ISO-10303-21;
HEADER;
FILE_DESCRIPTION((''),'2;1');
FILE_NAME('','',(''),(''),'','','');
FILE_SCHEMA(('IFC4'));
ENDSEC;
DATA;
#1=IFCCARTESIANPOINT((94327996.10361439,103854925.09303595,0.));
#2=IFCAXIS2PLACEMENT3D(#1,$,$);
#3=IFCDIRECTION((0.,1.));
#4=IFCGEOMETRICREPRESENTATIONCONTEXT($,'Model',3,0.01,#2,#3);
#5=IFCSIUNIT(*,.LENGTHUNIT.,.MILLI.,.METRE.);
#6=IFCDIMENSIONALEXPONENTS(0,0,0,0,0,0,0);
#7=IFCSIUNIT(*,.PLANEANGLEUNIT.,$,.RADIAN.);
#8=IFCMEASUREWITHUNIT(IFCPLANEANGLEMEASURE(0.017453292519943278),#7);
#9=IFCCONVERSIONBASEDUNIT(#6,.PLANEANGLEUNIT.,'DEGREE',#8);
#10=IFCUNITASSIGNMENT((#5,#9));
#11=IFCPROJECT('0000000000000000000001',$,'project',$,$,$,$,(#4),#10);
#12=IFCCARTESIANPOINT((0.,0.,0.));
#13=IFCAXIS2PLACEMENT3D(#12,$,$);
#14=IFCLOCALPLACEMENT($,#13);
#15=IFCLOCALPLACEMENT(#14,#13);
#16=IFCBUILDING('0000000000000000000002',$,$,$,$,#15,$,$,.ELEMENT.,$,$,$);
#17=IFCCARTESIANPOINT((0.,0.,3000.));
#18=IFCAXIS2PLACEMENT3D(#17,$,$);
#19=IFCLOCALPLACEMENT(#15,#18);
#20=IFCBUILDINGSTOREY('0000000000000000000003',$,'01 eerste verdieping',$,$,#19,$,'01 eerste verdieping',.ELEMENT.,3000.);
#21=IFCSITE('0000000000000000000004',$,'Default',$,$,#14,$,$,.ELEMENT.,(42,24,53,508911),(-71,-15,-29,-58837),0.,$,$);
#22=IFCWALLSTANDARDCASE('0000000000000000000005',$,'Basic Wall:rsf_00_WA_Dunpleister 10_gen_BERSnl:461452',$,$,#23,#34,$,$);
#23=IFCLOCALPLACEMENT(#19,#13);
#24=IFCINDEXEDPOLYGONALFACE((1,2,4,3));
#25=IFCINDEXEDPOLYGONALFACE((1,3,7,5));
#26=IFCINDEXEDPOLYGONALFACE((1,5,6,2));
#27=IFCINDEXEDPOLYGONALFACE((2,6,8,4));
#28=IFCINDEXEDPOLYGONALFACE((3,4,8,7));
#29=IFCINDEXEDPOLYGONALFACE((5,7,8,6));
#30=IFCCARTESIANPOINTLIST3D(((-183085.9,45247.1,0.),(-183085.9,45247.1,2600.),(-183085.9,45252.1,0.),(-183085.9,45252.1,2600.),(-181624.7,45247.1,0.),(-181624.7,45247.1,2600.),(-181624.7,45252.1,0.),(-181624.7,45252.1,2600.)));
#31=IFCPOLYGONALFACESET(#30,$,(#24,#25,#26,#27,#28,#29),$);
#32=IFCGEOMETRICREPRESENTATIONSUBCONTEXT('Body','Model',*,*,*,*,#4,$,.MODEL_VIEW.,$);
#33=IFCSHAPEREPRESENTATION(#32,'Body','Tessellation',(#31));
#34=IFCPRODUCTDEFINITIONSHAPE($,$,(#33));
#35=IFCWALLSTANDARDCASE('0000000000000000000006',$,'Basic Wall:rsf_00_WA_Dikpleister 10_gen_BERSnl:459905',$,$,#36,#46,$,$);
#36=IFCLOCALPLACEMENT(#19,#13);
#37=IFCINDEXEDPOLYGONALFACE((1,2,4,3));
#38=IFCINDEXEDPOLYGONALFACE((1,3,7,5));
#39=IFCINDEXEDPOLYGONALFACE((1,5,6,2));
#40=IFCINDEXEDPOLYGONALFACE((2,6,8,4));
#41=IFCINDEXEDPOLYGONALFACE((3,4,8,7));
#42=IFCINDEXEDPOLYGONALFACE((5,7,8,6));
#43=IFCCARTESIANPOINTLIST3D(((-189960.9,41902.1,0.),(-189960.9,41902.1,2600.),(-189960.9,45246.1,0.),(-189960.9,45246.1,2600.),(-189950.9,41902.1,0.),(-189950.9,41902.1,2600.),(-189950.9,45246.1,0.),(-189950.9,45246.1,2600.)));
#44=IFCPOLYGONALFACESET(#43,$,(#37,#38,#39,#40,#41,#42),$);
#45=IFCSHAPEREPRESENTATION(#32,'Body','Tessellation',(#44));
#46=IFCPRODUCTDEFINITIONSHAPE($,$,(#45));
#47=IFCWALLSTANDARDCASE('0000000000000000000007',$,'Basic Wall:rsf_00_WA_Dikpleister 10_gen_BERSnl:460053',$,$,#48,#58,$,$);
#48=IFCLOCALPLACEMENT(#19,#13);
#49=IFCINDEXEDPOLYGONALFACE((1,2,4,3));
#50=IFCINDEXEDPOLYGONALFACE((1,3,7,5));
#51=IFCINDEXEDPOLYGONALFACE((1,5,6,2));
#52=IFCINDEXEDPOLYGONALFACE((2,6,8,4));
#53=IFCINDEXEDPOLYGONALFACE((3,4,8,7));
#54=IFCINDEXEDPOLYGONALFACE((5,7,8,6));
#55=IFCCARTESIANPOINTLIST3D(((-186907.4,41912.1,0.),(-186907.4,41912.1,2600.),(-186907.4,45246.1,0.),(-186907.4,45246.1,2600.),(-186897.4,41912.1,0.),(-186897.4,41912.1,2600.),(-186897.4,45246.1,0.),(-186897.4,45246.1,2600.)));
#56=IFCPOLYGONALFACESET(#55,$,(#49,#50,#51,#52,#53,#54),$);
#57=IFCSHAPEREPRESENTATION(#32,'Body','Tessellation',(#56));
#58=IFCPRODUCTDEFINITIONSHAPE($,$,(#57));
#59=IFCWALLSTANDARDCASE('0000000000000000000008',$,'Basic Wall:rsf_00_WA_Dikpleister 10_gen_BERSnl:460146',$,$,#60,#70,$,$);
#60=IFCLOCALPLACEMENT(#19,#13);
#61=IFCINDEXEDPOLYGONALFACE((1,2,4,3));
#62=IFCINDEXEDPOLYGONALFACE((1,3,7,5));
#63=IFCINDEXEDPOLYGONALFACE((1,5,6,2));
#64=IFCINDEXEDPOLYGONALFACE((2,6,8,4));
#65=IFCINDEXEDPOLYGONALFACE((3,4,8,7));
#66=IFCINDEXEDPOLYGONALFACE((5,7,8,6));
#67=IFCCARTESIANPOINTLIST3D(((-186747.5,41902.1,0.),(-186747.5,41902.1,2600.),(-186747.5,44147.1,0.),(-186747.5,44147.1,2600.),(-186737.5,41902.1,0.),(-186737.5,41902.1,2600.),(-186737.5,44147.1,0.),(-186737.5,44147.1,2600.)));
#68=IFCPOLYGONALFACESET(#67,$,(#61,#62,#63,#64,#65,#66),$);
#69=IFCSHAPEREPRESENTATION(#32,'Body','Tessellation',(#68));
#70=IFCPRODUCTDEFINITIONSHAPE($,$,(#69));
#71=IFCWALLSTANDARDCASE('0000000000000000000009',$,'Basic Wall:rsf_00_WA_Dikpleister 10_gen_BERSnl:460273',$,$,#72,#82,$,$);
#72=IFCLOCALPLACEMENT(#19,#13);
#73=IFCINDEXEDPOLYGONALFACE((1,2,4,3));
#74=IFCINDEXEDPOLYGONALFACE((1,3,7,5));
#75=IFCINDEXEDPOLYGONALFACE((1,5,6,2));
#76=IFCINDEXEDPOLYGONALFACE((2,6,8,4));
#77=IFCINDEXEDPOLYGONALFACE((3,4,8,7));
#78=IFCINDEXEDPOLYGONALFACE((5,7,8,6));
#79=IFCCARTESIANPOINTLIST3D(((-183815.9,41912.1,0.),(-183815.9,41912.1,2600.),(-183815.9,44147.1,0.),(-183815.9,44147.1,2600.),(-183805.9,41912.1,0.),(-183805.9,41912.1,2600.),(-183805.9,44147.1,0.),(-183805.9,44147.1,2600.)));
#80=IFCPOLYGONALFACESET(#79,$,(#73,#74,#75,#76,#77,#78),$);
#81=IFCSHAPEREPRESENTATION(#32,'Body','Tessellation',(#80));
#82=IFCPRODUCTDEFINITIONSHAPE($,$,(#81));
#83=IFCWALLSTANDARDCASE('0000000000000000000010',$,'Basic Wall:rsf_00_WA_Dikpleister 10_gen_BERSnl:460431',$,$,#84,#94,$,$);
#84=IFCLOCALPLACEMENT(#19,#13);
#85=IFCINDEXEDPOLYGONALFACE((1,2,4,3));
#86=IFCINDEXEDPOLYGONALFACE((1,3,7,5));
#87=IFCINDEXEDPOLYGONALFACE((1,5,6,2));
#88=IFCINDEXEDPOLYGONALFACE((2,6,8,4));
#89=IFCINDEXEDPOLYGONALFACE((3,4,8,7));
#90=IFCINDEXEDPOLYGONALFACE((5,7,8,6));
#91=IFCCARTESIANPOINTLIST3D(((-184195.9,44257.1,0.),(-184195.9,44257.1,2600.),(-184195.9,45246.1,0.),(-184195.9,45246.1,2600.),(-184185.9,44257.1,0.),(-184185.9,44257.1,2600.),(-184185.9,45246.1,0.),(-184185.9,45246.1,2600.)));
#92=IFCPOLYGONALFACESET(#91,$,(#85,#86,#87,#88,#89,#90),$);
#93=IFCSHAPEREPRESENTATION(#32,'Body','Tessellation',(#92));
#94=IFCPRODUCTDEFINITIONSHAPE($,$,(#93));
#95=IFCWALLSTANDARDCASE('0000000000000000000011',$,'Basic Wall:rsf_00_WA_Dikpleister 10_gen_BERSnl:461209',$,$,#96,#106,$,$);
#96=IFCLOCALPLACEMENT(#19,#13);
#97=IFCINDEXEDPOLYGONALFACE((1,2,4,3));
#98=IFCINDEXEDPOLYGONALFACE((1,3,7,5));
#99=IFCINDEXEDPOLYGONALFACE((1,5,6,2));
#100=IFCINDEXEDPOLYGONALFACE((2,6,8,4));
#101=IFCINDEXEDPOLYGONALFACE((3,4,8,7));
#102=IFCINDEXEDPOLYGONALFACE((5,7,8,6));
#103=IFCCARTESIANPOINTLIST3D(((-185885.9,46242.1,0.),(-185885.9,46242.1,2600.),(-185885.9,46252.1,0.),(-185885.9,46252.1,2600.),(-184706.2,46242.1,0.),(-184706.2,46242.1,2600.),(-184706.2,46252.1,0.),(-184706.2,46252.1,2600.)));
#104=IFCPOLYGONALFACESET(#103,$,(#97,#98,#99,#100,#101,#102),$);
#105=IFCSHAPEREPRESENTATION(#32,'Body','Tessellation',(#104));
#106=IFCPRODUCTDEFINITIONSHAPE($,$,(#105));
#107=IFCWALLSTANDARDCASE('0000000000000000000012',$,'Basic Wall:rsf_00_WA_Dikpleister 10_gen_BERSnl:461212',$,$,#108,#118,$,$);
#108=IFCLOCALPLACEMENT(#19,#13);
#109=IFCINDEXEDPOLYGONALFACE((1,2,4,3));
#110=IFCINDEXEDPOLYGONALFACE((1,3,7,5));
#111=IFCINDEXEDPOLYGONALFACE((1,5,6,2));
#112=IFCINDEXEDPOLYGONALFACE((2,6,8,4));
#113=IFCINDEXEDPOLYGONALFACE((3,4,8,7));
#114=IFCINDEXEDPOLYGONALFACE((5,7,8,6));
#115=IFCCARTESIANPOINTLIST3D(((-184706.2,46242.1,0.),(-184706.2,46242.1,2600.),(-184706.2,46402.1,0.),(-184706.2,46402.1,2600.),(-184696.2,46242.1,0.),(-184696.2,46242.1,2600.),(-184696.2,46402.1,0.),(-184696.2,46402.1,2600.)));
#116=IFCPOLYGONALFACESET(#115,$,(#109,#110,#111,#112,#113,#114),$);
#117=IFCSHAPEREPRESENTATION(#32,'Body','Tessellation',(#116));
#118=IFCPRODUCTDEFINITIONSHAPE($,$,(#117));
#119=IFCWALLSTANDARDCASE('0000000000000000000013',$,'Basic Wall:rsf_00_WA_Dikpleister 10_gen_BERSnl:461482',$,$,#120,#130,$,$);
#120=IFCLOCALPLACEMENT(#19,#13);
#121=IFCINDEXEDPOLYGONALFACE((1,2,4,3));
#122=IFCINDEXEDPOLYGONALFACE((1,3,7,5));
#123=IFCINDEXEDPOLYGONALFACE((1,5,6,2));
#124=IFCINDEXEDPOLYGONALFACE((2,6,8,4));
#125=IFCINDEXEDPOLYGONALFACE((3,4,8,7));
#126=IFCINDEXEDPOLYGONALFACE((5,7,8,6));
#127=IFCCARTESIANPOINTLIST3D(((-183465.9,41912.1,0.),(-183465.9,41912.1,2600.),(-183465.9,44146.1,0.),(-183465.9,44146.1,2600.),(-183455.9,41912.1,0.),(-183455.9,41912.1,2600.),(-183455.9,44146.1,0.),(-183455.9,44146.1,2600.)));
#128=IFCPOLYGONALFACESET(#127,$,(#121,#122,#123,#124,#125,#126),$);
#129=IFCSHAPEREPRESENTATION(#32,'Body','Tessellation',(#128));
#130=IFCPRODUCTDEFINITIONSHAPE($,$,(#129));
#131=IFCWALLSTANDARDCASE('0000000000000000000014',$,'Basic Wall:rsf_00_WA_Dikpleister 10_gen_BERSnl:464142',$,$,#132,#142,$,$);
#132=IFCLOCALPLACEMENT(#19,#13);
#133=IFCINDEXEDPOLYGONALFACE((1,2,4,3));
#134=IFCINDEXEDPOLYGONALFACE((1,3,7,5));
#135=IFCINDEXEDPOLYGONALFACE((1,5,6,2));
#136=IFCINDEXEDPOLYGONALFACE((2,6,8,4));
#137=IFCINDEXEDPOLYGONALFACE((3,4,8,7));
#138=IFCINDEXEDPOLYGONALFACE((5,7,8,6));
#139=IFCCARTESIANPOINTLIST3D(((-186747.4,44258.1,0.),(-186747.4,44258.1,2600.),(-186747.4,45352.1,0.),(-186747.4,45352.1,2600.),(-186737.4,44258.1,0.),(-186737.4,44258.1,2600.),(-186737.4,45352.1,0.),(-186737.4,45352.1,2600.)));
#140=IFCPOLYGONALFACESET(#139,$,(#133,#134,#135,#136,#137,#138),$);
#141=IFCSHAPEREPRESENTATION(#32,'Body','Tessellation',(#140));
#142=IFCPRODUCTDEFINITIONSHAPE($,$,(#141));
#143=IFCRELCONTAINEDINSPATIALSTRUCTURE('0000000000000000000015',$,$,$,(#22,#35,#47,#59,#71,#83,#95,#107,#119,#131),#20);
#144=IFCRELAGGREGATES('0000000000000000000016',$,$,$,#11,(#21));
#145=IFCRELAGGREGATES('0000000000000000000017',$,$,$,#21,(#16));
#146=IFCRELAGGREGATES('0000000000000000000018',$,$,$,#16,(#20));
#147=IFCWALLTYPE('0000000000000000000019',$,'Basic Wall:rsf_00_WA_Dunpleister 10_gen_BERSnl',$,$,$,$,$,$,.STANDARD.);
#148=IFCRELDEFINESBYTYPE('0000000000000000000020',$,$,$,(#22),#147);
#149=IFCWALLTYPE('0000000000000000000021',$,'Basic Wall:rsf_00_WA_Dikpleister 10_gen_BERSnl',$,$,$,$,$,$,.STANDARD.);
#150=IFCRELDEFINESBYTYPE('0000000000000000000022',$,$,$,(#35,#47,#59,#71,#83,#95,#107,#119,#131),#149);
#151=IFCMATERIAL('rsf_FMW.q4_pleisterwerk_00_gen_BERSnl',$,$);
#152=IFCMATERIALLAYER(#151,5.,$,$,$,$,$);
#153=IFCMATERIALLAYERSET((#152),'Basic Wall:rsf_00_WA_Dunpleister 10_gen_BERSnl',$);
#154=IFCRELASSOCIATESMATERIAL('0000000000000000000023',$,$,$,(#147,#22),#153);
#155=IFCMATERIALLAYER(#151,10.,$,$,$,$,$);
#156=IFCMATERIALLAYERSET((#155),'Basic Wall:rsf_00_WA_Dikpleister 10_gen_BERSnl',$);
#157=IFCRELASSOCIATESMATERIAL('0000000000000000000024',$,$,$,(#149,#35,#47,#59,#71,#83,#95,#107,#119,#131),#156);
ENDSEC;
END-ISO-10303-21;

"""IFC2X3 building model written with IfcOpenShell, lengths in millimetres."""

from ifc_helpers import new_model, entity, si_unit, converted_unit, direction, frame, frame_2d, origin, place, context, subcontext, project, spatial, rectangle, extrude, material, layer, layer_set, layer_usage, type_object, element, save


model = new_model("IFC2X3")

# Units and contexts
model_context = context("Model", 3, precision=0.01, world=frame((94327996.10361439, 103854925.09303595, 0.0)), true_north=direction((0.0, 1.0)))
body_context = subcontext(model_context, "Body", "Model", "MODEL_VIEW")
ifc_project = project(units=[si_unit("LENGTHUNIT", "METRE", prefix="MILLI"), converted_unit("PLANEANGLEUNIT", "DEGREE", entity("IfcPlaneAngleMeasure", 0.017453292519943278), si_unit("PLANEANGLEUNIT", "RADIAN"), dimensions=[0, 0, 0, 0, 0, 0, 0])], contexts=[model_context])

# Site, building, storey
site_placement = place(None, origin())
site = spatial("IfcSite", under=ifc_project, at=site_placement, Name="Default", CompositionType="ELEMENT", RefLatitude=(42, 24, 53, 508911), RefLongitude=(-71, -15, -29, -58837), RefElevation=0.0)
building_placement = place(site_placement, origin())
building = spatial("IfcBuilding", under=site, at=building_placement, CompositionType="ELEMENT")
storey_placement = place(building_placement, frame((0.0, 0.0, 3000.0)))
storey = spatial("IfcBuildingStorey", under=building, at=storey_placement, Name="01 eerste verdieping", LongName="01 eerste verdieping", CompositionType="ELEMENT", Elevation=3000.0)

# Shared definitions
ifc_material_1 = material(Name="rsf_FMW.q4_pleisterwerk_00_gen_BERSnl")
ifc_layer_1 = layer(ifc_material_1, 5.0)
ifc_layer_set_1 = layer_set([ifc_layer_1], Name="Basic Wall:rsf_00_WA_Dunpleister 10_gen_BERSnl")
wall_type_1 = type_object("IfcWallType", Name="Basic Wall:rsf_00_WA_Dunpleister 10_gen_BERSnl", PredefinedType="STANDARD", material=ifc_layer_set_1)

# Wall
ifc_layer_usage_1 = layer_usage(ifc_layer_set_1, "AXIS2", "POSITIVE", -2.5)
wall_1_placement = place(storey_placement, frame((-183085.9, 45249.6, 0.0)))
element("IfcWallStandardCase", 1, at=wall_1_placement, inside=storey, type_object=wall_type_1, material=ifc_layer_usage_1, Name="Basic Wall:rsf_00_WA_Dunpleister 10_gen_BERSnl:461452", context=body_context, shape_type="SweptSolid", body=[
    extrude(rectangle(XDim=1461.2, YDim=5.0, at=frame_2d((730.6, 0.0), x_axis=(-1.0, 0.0))), origin(), (0.0, 0.0, 1.0), 2600.0),
])

# Walls
ifc_layer_2 = layer(ifc_material_1, 10.0)
ifc_layer_set_2 = layer_set([ifc_layer_2], Name="Basic Wall:rsf_00_WA_Dikpleister 10_gen_BERSnl")
ifc_layer_usage_2 = layer_usage(ifc_layer_set_2, "AXIS2", "NEGATIVE", 5.0)
wall_type_2 = type_object("IfcWallType", Name="Basic Wall:rsf_00_WA_Dikpleister 10_gen_BERSnl", PredefinedType="STANDARD", material=ifc_layer_set_2)
wall_2_placement = place(storey_placement, frame((-189955.9, 45246.1, 0.0), z_axis=(0.0, 0.0, 1.0), x_axis=(0.0, -1.0, 0.0)))
element("IfcWallStandardCase", 2, at=wall_2_placement, inside=storey, type_object=wall_type_2, material=ifc_layer_usage_2, Name="Basic Wall:rsf_00_WA_Dikpleister 10_gen_BERSnl:459905", context=body_context, shape_type="SweptSolid", body=[
    extrude(rectangle(XDim=3344.0, YDim=10.0, at=frame_2d((1672.0, 0.0), x_axis=(-1.0, 0.0))), origin(), (0.0, 0.0, 1.0), 2600.0),
])
ifc_layer_usage_3 = layer_usage(ifc_layer_set_2, "AXIS2", "NEGATIVE", 5.0)
wall_3_placement = place(storey_placement, frame((-186902.4, 41912.1, 0.0), z_axis=(0.0, 0.0, 1.0), x_axis=(0.0, 1.0, 0.0)))
element("IfcWallStandardCase", 3, at=wall_3_placement, inside=storey, type_object=wall_type_2, material=ifc_layer_usage_3, Name="Basic Wall:rsf_00_WA_Dikpleister 10_gen_BERSnl:460053", context=body_context, shape_type="SweptSolid", body=[
    extrude(rectangle(XDim=3334.0, YDim=10.0, at=frame_2d((1667.0, 0.0), x_axis=(-1.0, 0.0))), origin(), (0.0, 0.0, 1.0), 2600.0),
])
ifc_layer_usage_4 = layer_usage(ifc_layer_set_2, "AXIS2", "NEGATIVE", 5.0)
wall_4_placement = place(storey_placement, frame((-186742.5, 44147.1, 0.0), z_axis=(0.0, 0.0, 1.0), x_axis=(0.0, -1.0, 0.0)))
element("IfcWallStandardCase", 4, at=wall_4_placement, inside=storey, type_object=wall_type_2, material=ifc_layer_usage_4, Name="Basic Wall:rsf_00_WA_Dikpleister 10_gen_BERSnl:460146", context=body_context, shape_type="SweptSolid", body=[
    extrude(rectangle(XDim=2245.0, YDim=10.0, at=frame_2d((1122.5, 0.0), x_axis=(-1.0, 0.0))), origin(), (0.0, 0.0, 1.0), 2600.0),
])
ifc_layer_usage_5 = layer_usage(ifc_layer_set_2, "AXIS2", "NEGATIVE", 5.0)
wall_5_placement = place(storey_placement, frame((-183810.9, 41912.1, 0.0), z_axis=(0.0, 0.0, 1.0), x_axis=(0.0, 1.0, 0.0)))
element("IfcWallStandardCase", 5, at=wall_5_placement, inside=storey, type_object=wall_type_2, material=ifc_layer_usage_5, Name="Basic Wall:rsf_00_WA_Dikpleister 10_gen_BERSnl:460273", context=body_context, shape_type="SweptSolid", body=[
    extrude(rectangle(XDim=2235.0, YDim=10.0, at=frame_2d((1117.5, 0.0), x_axis=(-1.0, 0.0))), origin(), (0.0, 0.0, 1.0), 2600.0),
])
ifc_layer_usage_6 = layer_usage(ifc_layer_set_2, "AXIS2", "NEGATIVE", 5.0)
wall_6_placement = place(storey_placement, frame((-184190.9, 44257.1, 0.0), z_axis=(0.0, 0.0, 1.0), x_axis=(0.0, 1.0, 0.0)))
element("IfcWallStandardCase", 6, at=wall_6_placement, inside=storey, type_object=wall_type_2, material=ifc_layer_usage_6, Name="Basic Wall:rsf_00_WA_Dikpleister 10_gen_BERSnl:460431", context=body_context, shape_type="SweptSolid", body=[
    extrude(rectangle(XDim=989.0, YDim=10.0, at=frame_2d((494.5, 0.0), x_axis=(-1.0, 0.0))), origin(), (0.0, 0.0, 1.0), 2600.0),
])

# Walls
ifc_layer_usage_7 = layer_usage(ifc_layer_set_2, "AXIS2", "NEGATIVE", 5.0)
wall_7_placement = place(storey_placement, frame((-185885.9, 46247.1, 0.0)))
element("IfcWallStandardCase", 7, at=wall_7_placement, inside=storey, type_object=wall_type_2, material=ifc_layer_usage_7, Name="Basic Wall:rsf_00_WA_Dikpleister 10_gen_BERSnl:461209", context=body_context, shape_type="SweptSolid", body=[
    extrude(rectangle(XDim=1179.6, YDim=10.0, at=frame_2d((589.8, 0.0), x_axis=(-1.0, 0.0))), origin(), (0.0, 0.0, 1.0), 2600.0),
])
ifc_layer_usage_8 = layer_usage(ifc_layer_set_2, "AXIS2", "NEGATIVE", 5.0)
wall_8_placement = place(storey_placement, frame((-184701.2, 46242.1, 0.0), z_axis=(0.0, 0.0, 1.0), x_axis=(0.0, 1.0, 0.0)))
element("IfcWallStandardCase", 8, at=wall_8_placement, inside=storey, type_object=wall_type_2, material=ifc_layer_usage_8, Name="Basic Wall:rsf_00_WA_Dikpleister 10_gen_BERSnl:461212", context=body_context, shape_type="SweptSolid", body=[
    extrude(rectangle(XDim=160.0, YDim=10.0, at=frame_2d((80.0, 0.0), x_axis=(-1.0, 0.0))), origin(), (0.0, 0.0, 1.0), 2600.0),
])
ifc_layer_usage_9 = layer_usage(ifc_layer_set_2, "AXIS2", "POSITIVE", -5.0)
wall_9_placement = place(storey_placement, frame((-183460.9, 41912.1, 0.0), z_axis=(0.0, 0.0, 1.0), x_axis=(0.0, 1.0, 0.0)))
element("IfcWallStandardCase", 9, at=wall_9_placement, inside=storey, type_object=wall_type_2, material=ifc_layer_usage_9, Name="Basic Wall:rsf_00_WA_Dikpleister 10_gen_BERSnl:461482", context=body_context, shape_type="SweptSolid", body=[
    extrude(rectangle(XDim=2234.0, YDim=10.0, at=frame_2d((1117.0, 0.0), x_axis=(-1.0, 0.0))), origin(), (0.0, 0.0, 1.0), 2600.0),
])
ifc_layer_usage_10 = layer_usage(ifc_layer_set_2, "AXIS2", "POSITIVE", -5.0)
wall_10_placement = place(storey_placement, frame((-186742.4, 44258.1, 0.0), z_axis=(0.0, 0.0, 1.0), x_axis=(0.0, 1.0, 0.0)))
element("IfcWallStandardCase", 10, at=wall_10_placement, inside=storey, type_object=wall_type_2, material=ifc_layer_usage_10, Name="Basic Wall:rsf_00_WA_Dikpleister 10_gen_BERSnl:464142", context=body_context, shape_type="SweptSolid", body=[
    extrude(rectangle(XDim=1094.0, YDim=10.0, at=frame_2d((547.0, 0.0), x_axis=(-1.0, 0.0))), origin(), (0.0, 0.0, 1.0), 2600.0),
])

save(model, "model.ifc")
